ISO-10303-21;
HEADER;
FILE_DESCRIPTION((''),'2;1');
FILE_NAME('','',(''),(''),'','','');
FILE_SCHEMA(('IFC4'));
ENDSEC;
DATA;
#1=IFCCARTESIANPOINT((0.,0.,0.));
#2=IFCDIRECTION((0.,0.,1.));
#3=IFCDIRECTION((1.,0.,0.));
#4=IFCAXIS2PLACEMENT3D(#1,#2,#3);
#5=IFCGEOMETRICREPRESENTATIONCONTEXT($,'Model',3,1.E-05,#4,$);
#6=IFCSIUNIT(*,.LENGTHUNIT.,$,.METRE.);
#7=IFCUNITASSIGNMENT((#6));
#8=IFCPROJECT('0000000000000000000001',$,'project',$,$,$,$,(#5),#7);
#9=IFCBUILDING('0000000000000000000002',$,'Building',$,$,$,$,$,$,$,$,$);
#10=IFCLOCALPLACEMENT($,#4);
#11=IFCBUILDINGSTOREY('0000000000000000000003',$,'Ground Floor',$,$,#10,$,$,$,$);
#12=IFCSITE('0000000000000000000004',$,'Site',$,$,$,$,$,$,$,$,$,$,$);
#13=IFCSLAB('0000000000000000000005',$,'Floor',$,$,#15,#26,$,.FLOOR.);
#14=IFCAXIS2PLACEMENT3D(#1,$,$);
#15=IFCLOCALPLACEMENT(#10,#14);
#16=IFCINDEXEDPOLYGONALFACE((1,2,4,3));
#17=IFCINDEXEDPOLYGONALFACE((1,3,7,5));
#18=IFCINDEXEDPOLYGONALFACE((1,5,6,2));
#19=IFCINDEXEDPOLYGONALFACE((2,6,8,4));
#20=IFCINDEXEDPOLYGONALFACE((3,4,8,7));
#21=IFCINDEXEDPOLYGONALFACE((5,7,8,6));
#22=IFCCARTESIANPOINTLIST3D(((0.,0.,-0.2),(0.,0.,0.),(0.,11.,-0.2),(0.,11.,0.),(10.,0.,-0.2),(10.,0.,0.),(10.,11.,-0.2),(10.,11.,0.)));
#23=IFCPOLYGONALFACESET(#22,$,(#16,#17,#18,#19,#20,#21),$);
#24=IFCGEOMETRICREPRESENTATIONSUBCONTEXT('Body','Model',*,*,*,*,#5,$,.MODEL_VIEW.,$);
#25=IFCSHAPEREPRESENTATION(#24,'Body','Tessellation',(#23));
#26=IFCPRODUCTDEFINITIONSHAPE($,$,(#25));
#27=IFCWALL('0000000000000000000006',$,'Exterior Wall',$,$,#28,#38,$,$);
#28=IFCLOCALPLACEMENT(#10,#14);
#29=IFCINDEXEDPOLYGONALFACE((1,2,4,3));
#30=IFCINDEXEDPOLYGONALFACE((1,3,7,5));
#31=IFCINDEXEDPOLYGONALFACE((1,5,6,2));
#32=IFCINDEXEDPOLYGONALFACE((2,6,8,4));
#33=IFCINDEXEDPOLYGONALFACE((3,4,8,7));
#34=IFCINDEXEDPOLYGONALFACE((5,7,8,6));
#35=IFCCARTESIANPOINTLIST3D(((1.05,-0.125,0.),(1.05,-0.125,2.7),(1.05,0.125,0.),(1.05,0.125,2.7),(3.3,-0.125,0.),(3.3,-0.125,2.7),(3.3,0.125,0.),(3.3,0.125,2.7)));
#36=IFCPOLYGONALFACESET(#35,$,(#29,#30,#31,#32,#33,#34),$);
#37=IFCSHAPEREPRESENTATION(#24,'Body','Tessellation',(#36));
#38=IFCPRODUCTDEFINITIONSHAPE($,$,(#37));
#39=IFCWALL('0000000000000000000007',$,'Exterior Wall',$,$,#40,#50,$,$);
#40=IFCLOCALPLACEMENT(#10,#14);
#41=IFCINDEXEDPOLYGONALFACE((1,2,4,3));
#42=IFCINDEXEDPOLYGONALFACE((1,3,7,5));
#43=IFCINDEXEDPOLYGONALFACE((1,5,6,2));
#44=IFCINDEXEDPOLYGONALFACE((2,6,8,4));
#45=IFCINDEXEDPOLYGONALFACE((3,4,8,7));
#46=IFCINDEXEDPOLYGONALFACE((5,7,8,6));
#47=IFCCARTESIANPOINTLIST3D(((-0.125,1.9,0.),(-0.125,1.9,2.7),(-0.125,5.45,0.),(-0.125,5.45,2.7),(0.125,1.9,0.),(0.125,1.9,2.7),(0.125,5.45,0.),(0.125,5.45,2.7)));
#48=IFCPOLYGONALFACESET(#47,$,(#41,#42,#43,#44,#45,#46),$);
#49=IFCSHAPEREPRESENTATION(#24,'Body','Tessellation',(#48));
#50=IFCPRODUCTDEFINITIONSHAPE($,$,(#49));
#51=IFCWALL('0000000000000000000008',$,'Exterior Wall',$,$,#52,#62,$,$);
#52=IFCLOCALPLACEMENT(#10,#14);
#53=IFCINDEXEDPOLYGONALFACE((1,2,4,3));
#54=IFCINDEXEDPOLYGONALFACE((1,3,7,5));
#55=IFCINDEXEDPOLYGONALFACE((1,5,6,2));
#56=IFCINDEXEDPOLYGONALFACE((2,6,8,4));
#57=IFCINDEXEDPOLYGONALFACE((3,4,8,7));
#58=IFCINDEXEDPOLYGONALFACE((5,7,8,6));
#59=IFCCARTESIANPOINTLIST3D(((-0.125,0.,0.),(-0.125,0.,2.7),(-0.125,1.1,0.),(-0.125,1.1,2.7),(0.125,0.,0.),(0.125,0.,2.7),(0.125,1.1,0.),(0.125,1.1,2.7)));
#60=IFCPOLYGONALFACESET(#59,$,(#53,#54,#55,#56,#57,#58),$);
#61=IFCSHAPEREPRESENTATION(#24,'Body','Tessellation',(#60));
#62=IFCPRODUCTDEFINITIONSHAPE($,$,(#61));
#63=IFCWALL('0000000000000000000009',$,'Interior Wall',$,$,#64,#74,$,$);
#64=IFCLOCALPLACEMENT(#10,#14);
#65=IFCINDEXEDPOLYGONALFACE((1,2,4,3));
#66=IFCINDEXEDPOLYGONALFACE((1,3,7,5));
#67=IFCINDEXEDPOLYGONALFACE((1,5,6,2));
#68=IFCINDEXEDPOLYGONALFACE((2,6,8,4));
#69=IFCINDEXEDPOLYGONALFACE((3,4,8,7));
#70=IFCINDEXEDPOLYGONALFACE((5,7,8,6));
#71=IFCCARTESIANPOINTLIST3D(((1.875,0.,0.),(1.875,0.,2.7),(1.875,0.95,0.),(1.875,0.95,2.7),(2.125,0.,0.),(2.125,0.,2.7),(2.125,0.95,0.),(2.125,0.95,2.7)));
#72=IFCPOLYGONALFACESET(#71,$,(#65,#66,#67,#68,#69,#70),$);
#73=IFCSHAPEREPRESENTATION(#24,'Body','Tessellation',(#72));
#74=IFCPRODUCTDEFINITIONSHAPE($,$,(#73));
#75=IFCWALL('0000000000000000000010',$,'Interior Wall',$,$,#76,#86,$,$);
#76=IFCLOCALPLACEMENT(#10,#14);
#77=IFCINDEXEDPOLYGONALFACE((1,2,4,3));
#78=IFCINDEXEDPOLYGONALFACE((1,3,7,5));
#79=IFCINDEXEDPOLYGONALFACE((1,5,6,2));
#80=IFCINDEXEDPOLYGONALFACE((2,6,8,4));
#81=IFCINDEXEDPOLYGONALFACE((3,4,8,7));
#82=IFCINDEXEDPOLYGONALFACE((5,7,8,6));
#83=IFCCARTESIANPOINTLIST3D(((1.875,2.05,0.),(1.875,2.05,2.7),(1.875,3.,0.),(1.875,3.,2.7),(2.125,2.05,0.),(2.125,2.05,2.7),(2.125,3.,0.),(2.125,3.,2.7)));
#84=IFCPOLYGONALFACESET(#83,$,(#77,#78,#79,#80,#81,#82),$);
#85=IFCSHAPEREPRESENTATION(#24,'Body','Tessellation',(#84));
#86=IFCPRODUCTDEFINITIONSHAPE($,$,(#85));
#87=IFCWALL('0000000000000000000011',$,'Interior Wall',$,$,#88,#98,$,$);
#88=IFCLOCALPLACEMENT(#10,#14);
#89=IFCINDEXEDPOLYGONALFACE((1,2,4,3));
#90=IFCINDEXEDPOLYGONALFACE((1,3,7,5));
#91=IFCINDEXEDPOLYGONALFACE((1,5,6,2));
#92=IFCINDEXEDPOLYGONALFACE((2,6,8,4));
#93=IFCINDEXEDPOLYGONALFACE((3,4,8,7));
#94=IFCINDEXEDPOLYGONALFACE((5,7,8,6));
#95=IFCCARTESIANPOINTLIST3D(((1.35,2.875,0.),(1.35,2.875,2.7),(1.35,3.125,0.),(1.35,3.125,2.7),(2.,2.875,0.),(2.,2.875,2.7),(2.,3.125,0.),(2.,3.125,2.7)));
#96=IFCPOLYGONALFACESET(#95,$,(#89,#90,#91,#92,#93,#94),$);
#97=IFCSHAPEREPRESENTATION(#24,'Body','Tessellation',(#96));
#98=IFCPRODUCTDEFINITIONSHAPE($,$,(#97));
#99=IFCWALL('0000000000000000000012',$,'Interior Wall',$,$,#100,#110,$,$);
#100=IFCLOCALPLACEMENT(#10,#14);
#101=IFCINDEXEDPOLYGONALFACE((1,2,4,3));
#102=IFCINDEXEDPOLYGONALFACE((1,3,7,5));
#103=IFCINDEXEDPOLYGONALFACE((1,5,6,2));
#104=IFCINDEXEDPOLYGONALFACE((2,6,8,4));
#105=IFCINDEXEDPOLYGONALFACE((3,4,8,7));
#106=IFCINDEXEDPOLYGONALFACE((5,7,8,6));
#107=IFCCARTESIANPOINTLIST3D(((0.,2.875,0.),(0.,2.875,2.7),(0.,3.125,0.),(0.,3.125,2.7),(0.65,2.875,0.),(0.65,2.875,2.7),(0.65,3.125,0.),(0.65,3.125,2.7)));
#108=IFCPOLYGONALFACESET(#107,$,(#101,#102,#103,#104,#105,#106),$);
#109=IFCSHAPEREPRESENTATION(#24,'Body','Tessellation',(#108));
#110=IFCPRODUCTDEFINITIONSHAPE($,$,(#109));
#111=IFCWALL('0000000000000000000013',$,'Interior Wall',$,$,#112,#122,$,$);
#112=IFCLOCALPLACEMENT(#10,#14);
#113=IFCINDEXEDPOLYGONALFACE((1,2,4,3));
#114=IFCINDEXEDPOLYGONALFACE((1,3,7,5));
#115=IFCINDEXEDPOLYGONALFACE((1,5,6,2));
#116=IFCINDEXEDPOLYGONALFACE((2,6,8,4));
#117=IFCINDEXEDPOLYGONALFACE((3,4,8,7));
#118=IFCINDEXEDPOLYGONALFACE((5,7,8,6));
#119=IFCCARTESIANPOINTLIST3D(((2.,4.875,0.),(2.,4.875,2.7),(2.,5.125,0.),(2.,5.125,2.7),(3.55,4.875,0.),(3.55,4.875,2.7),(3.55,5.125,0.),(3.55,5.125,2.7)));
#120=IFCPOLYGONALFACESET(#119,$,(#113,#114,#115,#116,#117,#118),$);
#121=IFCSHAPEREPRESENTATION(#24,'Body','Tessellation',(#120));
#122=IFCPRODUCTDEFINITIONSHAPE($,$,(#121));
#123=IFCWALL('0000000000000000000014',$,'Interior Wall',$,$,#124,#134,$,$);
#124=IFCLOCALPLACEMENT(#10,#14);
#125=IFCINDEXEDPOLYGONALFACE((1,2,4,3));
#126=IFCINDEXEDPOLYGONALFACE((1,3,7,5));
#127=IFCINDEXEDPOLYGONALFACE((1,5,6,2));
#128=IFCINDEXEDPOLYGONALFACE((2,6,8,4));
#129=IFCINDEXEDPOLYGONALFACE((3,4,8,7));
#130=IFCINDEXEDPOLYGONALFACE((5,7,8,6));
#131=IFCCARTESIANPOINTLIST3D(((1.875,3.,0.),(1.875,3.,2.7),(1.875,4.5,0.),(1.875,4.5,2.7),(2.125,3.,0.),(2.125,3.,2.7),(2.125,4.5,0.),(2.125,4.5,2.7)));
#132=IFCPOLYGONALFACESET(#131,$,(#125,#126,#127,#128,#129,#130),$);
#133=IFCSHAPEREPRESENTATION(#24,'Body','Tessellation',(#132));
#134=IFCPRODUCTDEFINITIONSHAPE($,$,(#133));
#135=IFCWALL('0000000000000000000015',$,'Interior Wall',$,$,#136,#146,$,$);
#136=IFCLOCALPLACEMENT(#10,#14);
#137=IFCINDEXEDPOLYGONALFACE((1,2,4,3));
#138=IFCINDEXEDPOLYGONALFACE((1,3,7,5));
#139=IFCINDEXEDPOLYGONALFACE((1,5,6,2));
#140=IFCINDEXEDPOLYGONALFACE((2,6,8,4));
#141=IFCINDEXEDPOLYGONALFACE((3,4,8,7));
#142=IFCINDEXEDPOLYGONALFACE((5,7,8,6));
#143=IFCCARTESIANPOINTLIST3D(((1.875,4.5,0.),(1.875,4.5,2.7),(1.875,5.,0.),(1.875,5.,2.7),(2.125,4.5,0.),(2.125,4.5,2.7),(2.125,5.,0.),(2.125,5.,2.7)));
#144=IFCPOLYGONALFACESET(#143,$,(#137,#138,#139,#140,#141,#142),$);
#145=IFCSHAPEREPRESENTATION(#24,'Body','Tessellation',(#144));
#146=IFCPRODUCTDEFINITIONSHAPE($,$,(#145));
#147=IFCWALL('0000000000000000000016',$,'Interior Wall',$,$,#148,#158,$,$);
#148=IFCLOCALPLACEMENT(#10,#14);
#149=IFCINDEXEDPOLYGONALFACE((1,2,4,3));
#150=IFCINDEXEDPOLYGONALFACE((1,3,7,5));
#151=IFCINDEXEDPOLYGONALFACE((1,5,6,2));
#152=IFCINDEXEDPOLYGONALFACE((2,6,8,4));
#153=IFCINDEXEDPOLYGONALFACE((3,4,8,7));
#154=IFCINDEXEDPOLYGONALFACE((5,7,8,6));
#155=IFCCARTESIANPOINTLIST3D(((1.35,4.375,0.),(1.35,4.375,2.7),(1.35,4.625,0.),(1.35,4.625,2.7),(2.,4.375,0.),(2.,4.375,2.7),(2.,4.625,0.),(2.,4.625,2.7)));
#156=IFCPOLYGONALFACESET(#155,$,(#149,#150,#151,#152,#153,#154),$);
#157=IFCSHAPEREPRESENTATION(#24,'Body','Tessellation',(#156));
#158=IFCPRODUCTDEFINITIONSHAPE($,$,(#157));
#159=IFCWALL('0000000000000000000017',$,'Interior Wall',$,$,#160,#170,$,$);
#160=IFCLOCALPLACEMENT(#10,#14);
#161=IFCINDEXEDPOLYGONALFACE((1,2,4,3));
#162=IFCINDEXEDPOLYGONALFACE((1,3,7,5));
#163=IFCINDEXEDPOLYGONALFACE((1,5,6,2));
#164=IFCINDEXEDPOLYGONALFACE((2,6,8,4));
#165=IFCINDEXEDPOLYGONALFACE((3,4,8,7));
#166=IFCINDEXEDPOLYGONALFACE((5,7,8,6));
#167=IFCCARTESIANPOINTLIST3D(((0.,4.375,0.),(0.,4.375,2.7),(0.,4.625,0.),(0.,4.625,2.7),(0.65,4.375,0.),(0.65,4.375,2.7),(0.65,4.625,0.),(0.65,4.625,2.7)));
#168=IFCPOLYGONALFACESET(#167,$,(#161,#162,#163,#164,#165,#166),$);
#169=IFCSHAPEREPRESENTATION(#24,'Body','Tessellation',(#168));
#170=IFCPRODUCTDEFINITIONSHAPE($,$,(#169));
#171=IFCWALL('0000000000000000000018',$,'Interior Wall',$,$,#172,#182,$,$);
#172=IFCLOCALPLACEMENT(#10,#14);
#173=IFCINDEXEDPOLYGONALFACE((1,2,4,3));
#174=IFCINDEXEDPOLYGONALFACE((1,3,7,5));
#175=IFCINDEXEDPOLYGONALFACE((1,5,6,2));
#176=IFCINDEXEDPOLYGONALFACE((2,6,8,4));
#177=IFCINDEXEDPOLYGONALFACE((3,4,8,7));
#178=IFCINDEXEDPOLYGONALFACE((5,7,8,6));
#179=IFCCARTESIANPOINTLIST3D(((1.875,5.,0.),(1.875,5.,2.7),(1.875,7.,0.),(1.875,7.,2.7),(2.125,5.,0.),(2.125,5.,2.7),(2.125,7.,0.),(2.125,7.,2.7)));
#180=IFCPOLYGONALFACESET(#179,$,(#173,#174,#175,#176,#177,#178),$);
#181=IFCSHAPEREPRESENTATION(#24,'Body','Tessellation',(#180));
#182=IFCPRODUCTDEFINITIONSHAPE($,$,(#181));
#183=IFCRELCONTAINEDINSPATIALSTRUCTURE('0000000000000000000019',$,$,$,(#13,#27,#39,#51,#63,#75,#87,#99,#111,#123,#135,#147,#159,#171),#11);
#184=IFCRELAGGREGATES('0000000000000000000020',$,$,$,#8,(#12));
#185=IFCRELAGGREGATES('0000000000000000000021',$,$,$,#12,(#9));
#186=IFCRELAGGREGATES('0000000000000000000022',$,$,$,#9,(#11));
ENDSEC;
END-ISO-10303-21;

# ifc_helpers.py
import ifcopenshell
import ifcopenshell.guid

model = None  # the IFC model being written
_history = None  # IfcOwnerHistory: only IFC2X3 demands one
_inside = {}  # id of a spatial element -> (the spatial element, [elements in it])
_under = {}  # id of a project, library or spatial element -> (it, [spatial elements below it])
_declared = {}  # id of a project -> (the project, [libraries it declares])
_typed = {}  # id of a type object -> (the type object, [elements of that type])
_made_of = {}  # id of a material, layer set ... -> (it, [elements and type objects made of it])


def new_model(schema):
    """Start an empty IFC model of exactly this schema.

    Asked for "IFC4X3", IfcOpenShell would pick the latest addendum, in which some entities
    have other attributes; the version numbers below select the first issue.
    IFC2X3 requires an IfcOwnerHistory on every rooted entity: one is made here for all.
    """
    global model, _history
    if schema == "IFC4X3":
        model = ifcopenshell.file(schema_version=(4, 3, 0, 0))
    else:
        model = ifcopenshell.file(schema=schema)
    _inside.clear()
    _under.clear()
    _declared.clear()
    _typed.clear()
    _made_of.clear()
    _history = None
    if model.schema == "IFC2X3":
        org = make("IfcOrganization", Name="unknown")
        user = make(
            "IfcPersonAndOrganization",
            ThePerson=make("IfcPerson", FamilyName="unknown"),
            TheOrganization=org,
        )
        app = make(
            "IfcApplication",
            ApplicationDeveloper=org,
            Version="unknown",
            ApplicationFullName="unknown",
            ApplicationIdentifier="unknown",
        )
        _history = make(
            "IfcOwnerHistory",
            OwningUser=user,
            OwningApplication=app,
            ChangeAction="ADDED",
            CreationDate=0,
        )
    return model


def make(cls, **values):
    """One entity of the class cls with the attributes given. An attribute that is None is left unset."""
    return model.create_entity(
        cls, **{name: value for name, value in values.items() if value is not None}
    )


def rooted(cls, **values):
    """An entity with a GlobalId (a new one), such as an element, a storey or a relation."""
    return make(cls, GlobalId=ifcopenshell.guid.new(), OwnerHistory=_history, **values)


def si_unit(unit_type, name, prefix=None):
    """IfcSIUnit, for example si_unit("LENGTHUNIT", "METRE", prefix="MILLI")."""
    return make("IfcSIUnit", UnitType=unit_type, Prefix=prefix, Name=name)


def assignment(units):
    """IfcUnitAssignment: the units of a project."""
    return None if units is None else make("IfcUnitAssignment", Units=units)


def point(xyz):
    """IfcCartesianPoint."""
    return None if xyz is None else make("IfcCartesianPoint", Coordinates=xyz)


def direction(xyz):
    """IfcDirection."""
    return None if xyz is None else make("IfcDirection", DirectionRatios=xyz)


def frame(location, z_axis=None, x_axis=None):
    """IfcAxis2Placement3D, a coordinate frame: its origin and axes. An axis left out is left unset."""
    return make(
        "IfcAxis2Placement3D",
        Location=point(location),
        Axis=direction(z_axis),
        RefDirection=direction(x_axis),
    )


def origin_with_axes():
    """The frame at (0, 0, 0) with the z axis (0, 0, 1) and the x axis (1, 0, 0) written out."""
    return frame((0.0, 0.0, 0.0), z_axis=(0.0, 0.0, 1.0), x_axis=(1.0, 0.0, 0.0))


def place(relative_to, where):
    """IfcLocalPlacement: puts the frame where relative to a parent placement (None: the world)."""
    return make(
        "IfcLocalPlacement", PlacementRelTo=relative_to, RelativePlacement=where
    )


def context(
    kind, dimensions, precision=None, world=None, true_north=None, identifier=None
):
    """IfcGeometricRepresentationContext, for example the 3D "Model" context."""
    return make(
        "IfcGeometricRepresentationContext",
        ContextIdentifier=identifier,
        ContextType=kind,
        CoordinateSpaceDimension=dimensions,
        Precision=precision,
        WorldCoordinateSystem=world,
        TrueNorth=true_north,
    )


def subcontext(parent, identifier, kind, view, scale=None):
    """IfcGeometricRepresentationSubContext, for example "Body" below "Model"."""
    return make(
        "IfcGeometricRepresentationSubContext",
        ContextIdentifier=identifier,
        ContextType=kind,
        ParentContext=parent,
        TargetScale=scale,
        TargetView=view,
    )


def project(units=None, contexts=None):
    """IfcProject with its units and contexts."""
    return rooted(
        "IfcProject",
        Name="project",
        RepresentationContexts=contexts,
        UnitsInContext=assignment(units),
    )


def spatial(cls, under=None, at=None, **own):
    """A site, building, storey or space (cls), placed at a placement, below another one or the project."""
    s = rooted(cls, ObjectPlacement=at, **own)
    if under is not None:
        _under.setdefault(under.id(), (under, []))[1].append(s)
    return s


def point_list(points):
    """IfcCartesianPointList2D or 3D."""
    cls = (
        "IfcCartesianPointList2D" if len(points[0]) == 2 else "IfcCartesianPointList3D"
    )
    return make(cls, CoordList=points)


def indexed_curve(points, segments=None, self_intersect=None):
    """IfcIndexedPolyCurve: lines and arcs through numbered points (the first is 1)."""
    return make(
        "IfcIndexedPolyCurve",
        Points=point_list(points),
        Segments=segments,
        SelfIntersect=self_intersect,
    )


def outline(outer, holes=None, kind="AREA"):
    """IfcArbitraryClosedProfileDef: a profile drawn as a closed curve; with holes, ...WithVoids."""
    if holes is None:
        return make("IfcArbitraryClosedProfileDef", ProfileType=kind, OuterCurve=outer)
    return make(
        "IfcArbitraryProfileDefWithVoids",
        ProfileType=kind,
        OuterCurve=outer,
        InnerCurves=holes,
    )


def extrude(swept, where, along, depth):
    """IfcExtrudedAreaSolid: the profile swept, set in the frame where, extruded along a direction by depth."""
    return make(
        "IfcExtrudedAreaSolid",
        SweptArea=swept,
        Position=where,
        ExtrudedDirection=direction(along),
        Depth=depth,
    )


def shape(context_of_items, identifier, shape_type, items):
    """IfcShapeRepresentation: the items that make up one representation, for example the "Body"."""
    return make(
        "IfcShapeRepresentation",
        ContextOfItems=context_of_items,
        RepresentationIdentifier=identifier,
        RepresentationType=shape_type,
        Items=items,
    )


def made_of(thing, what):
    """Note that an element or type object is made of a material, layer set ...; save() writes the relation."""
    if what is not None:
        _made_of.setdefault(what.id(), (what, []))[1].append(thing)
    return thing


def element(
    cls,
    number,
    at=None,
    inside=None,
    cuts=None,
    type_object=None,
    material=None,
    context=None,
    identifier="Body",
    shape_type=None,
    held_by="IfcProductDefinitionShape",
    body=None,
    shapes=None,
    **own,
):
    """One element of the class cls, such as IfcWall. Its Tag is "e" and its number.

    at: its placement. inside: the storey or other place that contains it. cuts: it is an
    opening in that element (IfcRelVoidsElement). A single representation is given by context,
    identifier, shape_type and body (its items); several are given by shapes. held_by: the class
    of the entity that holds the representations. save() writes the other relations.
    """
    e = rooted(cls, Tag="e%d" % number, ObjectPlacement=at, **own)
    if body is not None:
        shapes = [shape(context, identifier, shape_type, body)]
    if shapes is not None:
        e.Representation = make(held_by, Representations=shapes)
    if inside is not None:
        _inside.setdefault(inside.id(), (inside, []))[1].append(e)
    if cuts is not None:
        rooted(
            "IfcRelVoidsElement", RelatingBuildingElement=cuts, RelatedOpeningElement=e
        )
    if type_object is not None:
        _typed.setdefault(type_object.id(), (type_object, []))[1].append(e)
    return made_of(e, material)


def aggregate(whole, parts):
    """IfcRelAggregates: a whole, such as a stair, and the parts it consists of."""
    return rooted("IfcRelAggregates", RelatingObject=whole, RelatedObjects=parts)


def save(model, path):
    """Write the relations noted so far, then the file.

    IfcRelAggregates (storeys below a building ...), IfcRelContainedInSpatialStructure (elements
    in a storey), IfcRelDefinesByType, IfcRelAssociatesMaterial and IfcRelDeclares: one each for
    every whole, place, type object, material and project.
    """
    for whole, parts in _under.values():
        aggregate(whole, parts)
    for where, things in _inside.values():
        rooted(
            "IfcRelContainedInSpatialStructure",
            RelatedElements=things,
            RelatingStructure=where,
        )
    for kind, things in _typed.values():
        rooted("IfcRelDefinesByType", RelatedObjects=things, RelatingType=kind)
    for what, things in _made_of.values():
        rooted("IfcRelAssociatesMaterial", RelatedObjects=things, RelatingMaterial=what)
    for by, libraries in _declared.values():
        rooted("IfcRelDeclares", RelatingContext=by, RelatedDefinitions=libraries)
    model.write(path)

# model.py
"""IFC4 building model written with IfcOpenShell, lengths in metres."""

from ifc_helpers import new_model, si_unit, frame, origin_with_axes, place, context, subcontext, project, spatial, indexed_curve, outline, extrude, element, save


model = new_model("IFC4")

# Units and contexts
model_context = context("Model", 3, precision=1e-05, world=origin_with_axes())
body_context = subcontext(model_context, "Body", "Model", "MODEL_VIEW")
ifc_project = project(units=[si_unit("LENGTHUNIT", "METRE")], contexts=[model_context])

# Site, building, storey
site = spatial("IfcSite", under=ifc_project, Name="Site")
building = spatial("IfcBuilding", under=site, Name="Building")
storey_placement = place(None, origin_with_axes())
storey = spatial("IfcBuildingStorey", under=building, at=storey_placement, Name="Ground Floor")

# Slab
slab_placement = place(storey_placement, frame((0.0, 0.0, -0.2), z_axis=(0.0, 0.0, 1.0), x_axis=(1.0, 0.0, 0.0)))
element("IfcSlab", 1, at=slab_placement, inside=storey, Name="Floor", PredefinedType="FLOOR", context=body_context, shape_type="SweptSolid", body=[
    extrude(outline(indexed_curve([(0.0, 0.0), (10.0, 0.0), (10.0, 11.0), (0.0, 11.0)])), None, (0.0, 0.0, 1.0), 0.2),
])

# Walls
wall_1_placement = place(storey_placement, frame((1.05, 0.0, 0.0), z_axis=(0.0, 0.0, 1.0), x_axis=(1.0, 0.0, 0.0)))
element("IfcWall", 2, at=wall_1_placement, inside=storey, Name="Exterior Wall", context=body_context, shape_type="SweptSolid", body=[
    extrude(outline(indexed_curve([(0.0, 0.0), (0.0, 0.25), (2.25, 0.25), (2.25, 0.0), (0.0, 0.0)], self_intersect=False)), frame((0.0, -0.125, 0.0), z_axis=(0.0, 0.0, 1.0), x_axis=(1.0, 0.0, 0.0)), (0.0, 0.0, 1.0), 2.7),
])
wall_2_placement = place(storey_placement, frame((0.0, 5.45, 0.0), z_axis=(0.0, 0.0, 1.0), x_axis=(0.0, -1.0, 0.0)))
element("IfcWall", 3, at=wall_2_placement, inside=storey, Name="Exterior Wall", context=body_context, shape_type="SweptSolid", body=[
    extrude(outline(indexed_curve([(0.0, 0.0), (0.0, 0.25), (3.55, 0.25), (3.55, 0.0), (0.0, 0.0)], self_intersect=False)), frame((0.0, -0.125, 0.0), z_axis=(0.0, 0.0, 1.0), x_axis=(1.0, 0.0, 0.0)), (0.0, 0.0, 1.0), 2.7),
])
wall_3_placement = place(storey_placement, frame((0.0, 1.1, 0.0), z_axis=(0.0, 0.0, 1.0), x_axis=(0.0, -1.0, 0.0)))
element("IfcWall", 4, at=wall_3_placement, inside=storey, Name="Exterior Wall", context=body_context, shape_type="SweptSolid", body=[
    extrude(outline(indexed_curve([(0.0, 0.0), (0.0, 0.25), (1.1, 0.25), (1.1, 0.0), (0.0, 0.0)], self_intersect=False)), frame((0.0, -0.125, 0.0), z_axis=(0.0, 0.0, 1.0), x_axis=(1.0, 0.0, 0.0)), (0.0, 0.0, 1.0), 2.7),
])
wall_4_placement = place(storey_placement, frame((2.0, 0.0, 0.0), z_axis=(0.0, 0.0, 1.0), x_axis=(0.0, 1.0, 0.0)))
element("IfcWall", 5, at=wall_4_placement, inside=storey, Name="Interior Wall", context=body_context, shape_type="SweptSolid", body=[
    extrude(outline(indexed_curve([(0.0, 0.0), (0.0, 0.25), (0.95, 0.25), (0.95, 0.0), (0.0, 0.0)], self_intersect=False)), frame((0.0, -0.125, 0.0), z_axis=(0.0, 0.0, 1.0), x_axis=(1.0, 0.0, 0.0)), (0.0, 0.0, 1.0), 2.7),
])
wall_5_placement = place(storey_placement, frame((2.0, 2.05, 0.0), z_axis=(0.0, 0.0, 1.0), x_axis=(0.0, 1.0, 0.0)))
element("IfcWall", 6, at=wall_5_placement, inside=storey, Name="Interior Wall", context=body_context, shape_type="SweptSolid", body=[
    extrude(outline(indexed_curve([(0.0, 0.0), (0.0, 0.25), (0.95, 0.25), (0.95, 0.0), (0.0, 0.0)], self_intersect=False)), frame((0.0, -0.125, 0.0), z_axis=(0.0, 0.0, 1.0), x_axis=(1.0, 0.0, 0.0)), (0.0, 0.0, 1.0), 2.7),
])
for number, where, z_axis, x_axis, name in (
    (7, (2.0, 3.0, 0.0), (0.0, 0.0, 1.0), (-1.0, 0.0, 0.0), "Interior Wall"),
    (8, (0.65, 3.0, 0.0), (0.0, 0.0, 1.0), (-1.0, 0.0, 0.0), "Interior Wall"),
):
    element("IfcWall", number, at=place(storey_placement, frame(where, z_axis=z_axis, x_axis=x_axis)), inside=storey, Name=name, context=body_context, shape_type="SweptSolid", body=[
        extrude(outline(indexed_curve([(0.0, 0.0), (0.0, 0.25), (0.65, 0.25), (0.65, 0.0), (0.0, 0.0)], self_intersect=False)), frame((0.0, -0.125, 0.0), z_axis=(0.0, 0.0, 1.0), x_axis=(1.0, 0.0, 0.0)), (0.0, 0.0, 1.0), 2.7),
    ])
wall_6_placement = place(storey_placement, frame((3.55, 5.0, 0.0), z_axis=(0.0, 0.0, 1.0), x_axis=(-1.0, 0.0, 0.0)))
element("IfcWall", 9, at=wall_6_placement, inside=storey, Name="Interior Wall", context=body_context, shape_type="SweptSolid", body=[
    extrude(outline(indexed_curve([(0.0, 0.0), (0.0, 0.25), (1.55, 0.25), (1.55, 0.0), (0.0, 0.0)], self_intersect=False)), frame((0.0, -0.125, 0.0), z_axis=(0.0, 0.0, 1.0), x_axis=(1.0, 0.0, 0.0)), (0.0, 0.0, 1.0), 2.7),
])
wall_7_placement = place(storey_placement, frame((2.0, 4.5, 0.0), z_axis=(0.0, 0.0, 1.0), x_axis=(0.0, -1.0, 0.0)))
element("IfcWall", 10, at=wall_7_placement, inside=storey, Name="Interior Wall", context=body_context, shape_type="SweptSolid", body=[
    extrude(outline(indexed_curve([(0.0, 0.0), (0.0, 0.25), (1.5, 0.25), (1.5, 0.0), (0.0, 0.0)], self_intersect=False)), frame((0.0, -0.125, 0.0), z_axis=(0.0, 0.0, 1.0), x_axis=(1.0, 0.0, 0.0)), (0.0, 0.0, 1.0), 2.7),
])
wall_8_placement = place(storey_placement, frame((2.0, 5.0, 0.0), z_axis=(0.0, 0.0, 1.0), x_axis=(0.0, -1.0, 0.0)))
element("IfcWall", 11, at=wall_8_placement, inside=storey, Name="Interior Wall", context=body_context, shape_type="SweptSolid", body=[
    extrude(outline(indexed_curve([(0.0, 0.0), (0.0, 0.25), (0.5, 0.25), (0.5, 0.0), (0.0, 0.0)], self_intersect=False)), frame((0.0, -0.125, 0.0), z_axis=(0.0, 0.0, 1.0), x_axis=(1.0, 0.0, 0.0)), (0.0, 0.0, 1.0), 2.7),
])
for number, where, z_axis, x_axis, name in (
    (12, (2.0, 4.5, 0.0), (0.0, 0.0, 1.0), (-1.0, 0.0, 0.0), "Interior Wall"),
    (13, (0.65, 4.5, 0.0), (0.0, 0.0, 1.0), (-1.0, 0.0, 0.0), "Interior Wall"),
):
    element("IfcWall", number, at=place(storey_placement, frame(where, z_axis=z_axis, x_axis=x_axis)), inside=storey, Name=name, context=body_context, shape_type="SweptSolid", body=[
        extrude(outline(indexed_curve([(0.0, 0.0), (0.0, 0.25), (0.65, 0.25), (0.65, 0.0), (0.0, 0.0)], self_intersect=False)), frame((0.0, -0.125, 0.0), z_axis=(0.0, 0.0, 1.0), x_axis=(1.0, 0.0, 0.0)), (0.0, 0.0, 1.0), 2.7),
    ])
wall_9_placement = place(storey_placement, frame((2.0, 5.0, 0.0), z_axis=(0.0, 0.0, 1.0), x_axis=(0.0, 1.0, 0.0)))
element("IfcWall", 14, at=wall_9_placement, inside=storey, Name="Interior Wall", context=body_context, shape_type="SweptSolid", body=[
    extrude(outline(indexed_curve([(0.0, 0.0), (0.0, 0.25), (2.0, 0.25), (2.0, 0.0), (0.0, 0.0)], self_intersect=False)), frame((0.0, -0.125, 0.0), z_axis=(0.0, 0.0, 1.0), x_axis=(1.0, 0.0, 0.0)), (0.0, 0.0, 1.0), 2.7),
])

save(model, "model.ifc")
